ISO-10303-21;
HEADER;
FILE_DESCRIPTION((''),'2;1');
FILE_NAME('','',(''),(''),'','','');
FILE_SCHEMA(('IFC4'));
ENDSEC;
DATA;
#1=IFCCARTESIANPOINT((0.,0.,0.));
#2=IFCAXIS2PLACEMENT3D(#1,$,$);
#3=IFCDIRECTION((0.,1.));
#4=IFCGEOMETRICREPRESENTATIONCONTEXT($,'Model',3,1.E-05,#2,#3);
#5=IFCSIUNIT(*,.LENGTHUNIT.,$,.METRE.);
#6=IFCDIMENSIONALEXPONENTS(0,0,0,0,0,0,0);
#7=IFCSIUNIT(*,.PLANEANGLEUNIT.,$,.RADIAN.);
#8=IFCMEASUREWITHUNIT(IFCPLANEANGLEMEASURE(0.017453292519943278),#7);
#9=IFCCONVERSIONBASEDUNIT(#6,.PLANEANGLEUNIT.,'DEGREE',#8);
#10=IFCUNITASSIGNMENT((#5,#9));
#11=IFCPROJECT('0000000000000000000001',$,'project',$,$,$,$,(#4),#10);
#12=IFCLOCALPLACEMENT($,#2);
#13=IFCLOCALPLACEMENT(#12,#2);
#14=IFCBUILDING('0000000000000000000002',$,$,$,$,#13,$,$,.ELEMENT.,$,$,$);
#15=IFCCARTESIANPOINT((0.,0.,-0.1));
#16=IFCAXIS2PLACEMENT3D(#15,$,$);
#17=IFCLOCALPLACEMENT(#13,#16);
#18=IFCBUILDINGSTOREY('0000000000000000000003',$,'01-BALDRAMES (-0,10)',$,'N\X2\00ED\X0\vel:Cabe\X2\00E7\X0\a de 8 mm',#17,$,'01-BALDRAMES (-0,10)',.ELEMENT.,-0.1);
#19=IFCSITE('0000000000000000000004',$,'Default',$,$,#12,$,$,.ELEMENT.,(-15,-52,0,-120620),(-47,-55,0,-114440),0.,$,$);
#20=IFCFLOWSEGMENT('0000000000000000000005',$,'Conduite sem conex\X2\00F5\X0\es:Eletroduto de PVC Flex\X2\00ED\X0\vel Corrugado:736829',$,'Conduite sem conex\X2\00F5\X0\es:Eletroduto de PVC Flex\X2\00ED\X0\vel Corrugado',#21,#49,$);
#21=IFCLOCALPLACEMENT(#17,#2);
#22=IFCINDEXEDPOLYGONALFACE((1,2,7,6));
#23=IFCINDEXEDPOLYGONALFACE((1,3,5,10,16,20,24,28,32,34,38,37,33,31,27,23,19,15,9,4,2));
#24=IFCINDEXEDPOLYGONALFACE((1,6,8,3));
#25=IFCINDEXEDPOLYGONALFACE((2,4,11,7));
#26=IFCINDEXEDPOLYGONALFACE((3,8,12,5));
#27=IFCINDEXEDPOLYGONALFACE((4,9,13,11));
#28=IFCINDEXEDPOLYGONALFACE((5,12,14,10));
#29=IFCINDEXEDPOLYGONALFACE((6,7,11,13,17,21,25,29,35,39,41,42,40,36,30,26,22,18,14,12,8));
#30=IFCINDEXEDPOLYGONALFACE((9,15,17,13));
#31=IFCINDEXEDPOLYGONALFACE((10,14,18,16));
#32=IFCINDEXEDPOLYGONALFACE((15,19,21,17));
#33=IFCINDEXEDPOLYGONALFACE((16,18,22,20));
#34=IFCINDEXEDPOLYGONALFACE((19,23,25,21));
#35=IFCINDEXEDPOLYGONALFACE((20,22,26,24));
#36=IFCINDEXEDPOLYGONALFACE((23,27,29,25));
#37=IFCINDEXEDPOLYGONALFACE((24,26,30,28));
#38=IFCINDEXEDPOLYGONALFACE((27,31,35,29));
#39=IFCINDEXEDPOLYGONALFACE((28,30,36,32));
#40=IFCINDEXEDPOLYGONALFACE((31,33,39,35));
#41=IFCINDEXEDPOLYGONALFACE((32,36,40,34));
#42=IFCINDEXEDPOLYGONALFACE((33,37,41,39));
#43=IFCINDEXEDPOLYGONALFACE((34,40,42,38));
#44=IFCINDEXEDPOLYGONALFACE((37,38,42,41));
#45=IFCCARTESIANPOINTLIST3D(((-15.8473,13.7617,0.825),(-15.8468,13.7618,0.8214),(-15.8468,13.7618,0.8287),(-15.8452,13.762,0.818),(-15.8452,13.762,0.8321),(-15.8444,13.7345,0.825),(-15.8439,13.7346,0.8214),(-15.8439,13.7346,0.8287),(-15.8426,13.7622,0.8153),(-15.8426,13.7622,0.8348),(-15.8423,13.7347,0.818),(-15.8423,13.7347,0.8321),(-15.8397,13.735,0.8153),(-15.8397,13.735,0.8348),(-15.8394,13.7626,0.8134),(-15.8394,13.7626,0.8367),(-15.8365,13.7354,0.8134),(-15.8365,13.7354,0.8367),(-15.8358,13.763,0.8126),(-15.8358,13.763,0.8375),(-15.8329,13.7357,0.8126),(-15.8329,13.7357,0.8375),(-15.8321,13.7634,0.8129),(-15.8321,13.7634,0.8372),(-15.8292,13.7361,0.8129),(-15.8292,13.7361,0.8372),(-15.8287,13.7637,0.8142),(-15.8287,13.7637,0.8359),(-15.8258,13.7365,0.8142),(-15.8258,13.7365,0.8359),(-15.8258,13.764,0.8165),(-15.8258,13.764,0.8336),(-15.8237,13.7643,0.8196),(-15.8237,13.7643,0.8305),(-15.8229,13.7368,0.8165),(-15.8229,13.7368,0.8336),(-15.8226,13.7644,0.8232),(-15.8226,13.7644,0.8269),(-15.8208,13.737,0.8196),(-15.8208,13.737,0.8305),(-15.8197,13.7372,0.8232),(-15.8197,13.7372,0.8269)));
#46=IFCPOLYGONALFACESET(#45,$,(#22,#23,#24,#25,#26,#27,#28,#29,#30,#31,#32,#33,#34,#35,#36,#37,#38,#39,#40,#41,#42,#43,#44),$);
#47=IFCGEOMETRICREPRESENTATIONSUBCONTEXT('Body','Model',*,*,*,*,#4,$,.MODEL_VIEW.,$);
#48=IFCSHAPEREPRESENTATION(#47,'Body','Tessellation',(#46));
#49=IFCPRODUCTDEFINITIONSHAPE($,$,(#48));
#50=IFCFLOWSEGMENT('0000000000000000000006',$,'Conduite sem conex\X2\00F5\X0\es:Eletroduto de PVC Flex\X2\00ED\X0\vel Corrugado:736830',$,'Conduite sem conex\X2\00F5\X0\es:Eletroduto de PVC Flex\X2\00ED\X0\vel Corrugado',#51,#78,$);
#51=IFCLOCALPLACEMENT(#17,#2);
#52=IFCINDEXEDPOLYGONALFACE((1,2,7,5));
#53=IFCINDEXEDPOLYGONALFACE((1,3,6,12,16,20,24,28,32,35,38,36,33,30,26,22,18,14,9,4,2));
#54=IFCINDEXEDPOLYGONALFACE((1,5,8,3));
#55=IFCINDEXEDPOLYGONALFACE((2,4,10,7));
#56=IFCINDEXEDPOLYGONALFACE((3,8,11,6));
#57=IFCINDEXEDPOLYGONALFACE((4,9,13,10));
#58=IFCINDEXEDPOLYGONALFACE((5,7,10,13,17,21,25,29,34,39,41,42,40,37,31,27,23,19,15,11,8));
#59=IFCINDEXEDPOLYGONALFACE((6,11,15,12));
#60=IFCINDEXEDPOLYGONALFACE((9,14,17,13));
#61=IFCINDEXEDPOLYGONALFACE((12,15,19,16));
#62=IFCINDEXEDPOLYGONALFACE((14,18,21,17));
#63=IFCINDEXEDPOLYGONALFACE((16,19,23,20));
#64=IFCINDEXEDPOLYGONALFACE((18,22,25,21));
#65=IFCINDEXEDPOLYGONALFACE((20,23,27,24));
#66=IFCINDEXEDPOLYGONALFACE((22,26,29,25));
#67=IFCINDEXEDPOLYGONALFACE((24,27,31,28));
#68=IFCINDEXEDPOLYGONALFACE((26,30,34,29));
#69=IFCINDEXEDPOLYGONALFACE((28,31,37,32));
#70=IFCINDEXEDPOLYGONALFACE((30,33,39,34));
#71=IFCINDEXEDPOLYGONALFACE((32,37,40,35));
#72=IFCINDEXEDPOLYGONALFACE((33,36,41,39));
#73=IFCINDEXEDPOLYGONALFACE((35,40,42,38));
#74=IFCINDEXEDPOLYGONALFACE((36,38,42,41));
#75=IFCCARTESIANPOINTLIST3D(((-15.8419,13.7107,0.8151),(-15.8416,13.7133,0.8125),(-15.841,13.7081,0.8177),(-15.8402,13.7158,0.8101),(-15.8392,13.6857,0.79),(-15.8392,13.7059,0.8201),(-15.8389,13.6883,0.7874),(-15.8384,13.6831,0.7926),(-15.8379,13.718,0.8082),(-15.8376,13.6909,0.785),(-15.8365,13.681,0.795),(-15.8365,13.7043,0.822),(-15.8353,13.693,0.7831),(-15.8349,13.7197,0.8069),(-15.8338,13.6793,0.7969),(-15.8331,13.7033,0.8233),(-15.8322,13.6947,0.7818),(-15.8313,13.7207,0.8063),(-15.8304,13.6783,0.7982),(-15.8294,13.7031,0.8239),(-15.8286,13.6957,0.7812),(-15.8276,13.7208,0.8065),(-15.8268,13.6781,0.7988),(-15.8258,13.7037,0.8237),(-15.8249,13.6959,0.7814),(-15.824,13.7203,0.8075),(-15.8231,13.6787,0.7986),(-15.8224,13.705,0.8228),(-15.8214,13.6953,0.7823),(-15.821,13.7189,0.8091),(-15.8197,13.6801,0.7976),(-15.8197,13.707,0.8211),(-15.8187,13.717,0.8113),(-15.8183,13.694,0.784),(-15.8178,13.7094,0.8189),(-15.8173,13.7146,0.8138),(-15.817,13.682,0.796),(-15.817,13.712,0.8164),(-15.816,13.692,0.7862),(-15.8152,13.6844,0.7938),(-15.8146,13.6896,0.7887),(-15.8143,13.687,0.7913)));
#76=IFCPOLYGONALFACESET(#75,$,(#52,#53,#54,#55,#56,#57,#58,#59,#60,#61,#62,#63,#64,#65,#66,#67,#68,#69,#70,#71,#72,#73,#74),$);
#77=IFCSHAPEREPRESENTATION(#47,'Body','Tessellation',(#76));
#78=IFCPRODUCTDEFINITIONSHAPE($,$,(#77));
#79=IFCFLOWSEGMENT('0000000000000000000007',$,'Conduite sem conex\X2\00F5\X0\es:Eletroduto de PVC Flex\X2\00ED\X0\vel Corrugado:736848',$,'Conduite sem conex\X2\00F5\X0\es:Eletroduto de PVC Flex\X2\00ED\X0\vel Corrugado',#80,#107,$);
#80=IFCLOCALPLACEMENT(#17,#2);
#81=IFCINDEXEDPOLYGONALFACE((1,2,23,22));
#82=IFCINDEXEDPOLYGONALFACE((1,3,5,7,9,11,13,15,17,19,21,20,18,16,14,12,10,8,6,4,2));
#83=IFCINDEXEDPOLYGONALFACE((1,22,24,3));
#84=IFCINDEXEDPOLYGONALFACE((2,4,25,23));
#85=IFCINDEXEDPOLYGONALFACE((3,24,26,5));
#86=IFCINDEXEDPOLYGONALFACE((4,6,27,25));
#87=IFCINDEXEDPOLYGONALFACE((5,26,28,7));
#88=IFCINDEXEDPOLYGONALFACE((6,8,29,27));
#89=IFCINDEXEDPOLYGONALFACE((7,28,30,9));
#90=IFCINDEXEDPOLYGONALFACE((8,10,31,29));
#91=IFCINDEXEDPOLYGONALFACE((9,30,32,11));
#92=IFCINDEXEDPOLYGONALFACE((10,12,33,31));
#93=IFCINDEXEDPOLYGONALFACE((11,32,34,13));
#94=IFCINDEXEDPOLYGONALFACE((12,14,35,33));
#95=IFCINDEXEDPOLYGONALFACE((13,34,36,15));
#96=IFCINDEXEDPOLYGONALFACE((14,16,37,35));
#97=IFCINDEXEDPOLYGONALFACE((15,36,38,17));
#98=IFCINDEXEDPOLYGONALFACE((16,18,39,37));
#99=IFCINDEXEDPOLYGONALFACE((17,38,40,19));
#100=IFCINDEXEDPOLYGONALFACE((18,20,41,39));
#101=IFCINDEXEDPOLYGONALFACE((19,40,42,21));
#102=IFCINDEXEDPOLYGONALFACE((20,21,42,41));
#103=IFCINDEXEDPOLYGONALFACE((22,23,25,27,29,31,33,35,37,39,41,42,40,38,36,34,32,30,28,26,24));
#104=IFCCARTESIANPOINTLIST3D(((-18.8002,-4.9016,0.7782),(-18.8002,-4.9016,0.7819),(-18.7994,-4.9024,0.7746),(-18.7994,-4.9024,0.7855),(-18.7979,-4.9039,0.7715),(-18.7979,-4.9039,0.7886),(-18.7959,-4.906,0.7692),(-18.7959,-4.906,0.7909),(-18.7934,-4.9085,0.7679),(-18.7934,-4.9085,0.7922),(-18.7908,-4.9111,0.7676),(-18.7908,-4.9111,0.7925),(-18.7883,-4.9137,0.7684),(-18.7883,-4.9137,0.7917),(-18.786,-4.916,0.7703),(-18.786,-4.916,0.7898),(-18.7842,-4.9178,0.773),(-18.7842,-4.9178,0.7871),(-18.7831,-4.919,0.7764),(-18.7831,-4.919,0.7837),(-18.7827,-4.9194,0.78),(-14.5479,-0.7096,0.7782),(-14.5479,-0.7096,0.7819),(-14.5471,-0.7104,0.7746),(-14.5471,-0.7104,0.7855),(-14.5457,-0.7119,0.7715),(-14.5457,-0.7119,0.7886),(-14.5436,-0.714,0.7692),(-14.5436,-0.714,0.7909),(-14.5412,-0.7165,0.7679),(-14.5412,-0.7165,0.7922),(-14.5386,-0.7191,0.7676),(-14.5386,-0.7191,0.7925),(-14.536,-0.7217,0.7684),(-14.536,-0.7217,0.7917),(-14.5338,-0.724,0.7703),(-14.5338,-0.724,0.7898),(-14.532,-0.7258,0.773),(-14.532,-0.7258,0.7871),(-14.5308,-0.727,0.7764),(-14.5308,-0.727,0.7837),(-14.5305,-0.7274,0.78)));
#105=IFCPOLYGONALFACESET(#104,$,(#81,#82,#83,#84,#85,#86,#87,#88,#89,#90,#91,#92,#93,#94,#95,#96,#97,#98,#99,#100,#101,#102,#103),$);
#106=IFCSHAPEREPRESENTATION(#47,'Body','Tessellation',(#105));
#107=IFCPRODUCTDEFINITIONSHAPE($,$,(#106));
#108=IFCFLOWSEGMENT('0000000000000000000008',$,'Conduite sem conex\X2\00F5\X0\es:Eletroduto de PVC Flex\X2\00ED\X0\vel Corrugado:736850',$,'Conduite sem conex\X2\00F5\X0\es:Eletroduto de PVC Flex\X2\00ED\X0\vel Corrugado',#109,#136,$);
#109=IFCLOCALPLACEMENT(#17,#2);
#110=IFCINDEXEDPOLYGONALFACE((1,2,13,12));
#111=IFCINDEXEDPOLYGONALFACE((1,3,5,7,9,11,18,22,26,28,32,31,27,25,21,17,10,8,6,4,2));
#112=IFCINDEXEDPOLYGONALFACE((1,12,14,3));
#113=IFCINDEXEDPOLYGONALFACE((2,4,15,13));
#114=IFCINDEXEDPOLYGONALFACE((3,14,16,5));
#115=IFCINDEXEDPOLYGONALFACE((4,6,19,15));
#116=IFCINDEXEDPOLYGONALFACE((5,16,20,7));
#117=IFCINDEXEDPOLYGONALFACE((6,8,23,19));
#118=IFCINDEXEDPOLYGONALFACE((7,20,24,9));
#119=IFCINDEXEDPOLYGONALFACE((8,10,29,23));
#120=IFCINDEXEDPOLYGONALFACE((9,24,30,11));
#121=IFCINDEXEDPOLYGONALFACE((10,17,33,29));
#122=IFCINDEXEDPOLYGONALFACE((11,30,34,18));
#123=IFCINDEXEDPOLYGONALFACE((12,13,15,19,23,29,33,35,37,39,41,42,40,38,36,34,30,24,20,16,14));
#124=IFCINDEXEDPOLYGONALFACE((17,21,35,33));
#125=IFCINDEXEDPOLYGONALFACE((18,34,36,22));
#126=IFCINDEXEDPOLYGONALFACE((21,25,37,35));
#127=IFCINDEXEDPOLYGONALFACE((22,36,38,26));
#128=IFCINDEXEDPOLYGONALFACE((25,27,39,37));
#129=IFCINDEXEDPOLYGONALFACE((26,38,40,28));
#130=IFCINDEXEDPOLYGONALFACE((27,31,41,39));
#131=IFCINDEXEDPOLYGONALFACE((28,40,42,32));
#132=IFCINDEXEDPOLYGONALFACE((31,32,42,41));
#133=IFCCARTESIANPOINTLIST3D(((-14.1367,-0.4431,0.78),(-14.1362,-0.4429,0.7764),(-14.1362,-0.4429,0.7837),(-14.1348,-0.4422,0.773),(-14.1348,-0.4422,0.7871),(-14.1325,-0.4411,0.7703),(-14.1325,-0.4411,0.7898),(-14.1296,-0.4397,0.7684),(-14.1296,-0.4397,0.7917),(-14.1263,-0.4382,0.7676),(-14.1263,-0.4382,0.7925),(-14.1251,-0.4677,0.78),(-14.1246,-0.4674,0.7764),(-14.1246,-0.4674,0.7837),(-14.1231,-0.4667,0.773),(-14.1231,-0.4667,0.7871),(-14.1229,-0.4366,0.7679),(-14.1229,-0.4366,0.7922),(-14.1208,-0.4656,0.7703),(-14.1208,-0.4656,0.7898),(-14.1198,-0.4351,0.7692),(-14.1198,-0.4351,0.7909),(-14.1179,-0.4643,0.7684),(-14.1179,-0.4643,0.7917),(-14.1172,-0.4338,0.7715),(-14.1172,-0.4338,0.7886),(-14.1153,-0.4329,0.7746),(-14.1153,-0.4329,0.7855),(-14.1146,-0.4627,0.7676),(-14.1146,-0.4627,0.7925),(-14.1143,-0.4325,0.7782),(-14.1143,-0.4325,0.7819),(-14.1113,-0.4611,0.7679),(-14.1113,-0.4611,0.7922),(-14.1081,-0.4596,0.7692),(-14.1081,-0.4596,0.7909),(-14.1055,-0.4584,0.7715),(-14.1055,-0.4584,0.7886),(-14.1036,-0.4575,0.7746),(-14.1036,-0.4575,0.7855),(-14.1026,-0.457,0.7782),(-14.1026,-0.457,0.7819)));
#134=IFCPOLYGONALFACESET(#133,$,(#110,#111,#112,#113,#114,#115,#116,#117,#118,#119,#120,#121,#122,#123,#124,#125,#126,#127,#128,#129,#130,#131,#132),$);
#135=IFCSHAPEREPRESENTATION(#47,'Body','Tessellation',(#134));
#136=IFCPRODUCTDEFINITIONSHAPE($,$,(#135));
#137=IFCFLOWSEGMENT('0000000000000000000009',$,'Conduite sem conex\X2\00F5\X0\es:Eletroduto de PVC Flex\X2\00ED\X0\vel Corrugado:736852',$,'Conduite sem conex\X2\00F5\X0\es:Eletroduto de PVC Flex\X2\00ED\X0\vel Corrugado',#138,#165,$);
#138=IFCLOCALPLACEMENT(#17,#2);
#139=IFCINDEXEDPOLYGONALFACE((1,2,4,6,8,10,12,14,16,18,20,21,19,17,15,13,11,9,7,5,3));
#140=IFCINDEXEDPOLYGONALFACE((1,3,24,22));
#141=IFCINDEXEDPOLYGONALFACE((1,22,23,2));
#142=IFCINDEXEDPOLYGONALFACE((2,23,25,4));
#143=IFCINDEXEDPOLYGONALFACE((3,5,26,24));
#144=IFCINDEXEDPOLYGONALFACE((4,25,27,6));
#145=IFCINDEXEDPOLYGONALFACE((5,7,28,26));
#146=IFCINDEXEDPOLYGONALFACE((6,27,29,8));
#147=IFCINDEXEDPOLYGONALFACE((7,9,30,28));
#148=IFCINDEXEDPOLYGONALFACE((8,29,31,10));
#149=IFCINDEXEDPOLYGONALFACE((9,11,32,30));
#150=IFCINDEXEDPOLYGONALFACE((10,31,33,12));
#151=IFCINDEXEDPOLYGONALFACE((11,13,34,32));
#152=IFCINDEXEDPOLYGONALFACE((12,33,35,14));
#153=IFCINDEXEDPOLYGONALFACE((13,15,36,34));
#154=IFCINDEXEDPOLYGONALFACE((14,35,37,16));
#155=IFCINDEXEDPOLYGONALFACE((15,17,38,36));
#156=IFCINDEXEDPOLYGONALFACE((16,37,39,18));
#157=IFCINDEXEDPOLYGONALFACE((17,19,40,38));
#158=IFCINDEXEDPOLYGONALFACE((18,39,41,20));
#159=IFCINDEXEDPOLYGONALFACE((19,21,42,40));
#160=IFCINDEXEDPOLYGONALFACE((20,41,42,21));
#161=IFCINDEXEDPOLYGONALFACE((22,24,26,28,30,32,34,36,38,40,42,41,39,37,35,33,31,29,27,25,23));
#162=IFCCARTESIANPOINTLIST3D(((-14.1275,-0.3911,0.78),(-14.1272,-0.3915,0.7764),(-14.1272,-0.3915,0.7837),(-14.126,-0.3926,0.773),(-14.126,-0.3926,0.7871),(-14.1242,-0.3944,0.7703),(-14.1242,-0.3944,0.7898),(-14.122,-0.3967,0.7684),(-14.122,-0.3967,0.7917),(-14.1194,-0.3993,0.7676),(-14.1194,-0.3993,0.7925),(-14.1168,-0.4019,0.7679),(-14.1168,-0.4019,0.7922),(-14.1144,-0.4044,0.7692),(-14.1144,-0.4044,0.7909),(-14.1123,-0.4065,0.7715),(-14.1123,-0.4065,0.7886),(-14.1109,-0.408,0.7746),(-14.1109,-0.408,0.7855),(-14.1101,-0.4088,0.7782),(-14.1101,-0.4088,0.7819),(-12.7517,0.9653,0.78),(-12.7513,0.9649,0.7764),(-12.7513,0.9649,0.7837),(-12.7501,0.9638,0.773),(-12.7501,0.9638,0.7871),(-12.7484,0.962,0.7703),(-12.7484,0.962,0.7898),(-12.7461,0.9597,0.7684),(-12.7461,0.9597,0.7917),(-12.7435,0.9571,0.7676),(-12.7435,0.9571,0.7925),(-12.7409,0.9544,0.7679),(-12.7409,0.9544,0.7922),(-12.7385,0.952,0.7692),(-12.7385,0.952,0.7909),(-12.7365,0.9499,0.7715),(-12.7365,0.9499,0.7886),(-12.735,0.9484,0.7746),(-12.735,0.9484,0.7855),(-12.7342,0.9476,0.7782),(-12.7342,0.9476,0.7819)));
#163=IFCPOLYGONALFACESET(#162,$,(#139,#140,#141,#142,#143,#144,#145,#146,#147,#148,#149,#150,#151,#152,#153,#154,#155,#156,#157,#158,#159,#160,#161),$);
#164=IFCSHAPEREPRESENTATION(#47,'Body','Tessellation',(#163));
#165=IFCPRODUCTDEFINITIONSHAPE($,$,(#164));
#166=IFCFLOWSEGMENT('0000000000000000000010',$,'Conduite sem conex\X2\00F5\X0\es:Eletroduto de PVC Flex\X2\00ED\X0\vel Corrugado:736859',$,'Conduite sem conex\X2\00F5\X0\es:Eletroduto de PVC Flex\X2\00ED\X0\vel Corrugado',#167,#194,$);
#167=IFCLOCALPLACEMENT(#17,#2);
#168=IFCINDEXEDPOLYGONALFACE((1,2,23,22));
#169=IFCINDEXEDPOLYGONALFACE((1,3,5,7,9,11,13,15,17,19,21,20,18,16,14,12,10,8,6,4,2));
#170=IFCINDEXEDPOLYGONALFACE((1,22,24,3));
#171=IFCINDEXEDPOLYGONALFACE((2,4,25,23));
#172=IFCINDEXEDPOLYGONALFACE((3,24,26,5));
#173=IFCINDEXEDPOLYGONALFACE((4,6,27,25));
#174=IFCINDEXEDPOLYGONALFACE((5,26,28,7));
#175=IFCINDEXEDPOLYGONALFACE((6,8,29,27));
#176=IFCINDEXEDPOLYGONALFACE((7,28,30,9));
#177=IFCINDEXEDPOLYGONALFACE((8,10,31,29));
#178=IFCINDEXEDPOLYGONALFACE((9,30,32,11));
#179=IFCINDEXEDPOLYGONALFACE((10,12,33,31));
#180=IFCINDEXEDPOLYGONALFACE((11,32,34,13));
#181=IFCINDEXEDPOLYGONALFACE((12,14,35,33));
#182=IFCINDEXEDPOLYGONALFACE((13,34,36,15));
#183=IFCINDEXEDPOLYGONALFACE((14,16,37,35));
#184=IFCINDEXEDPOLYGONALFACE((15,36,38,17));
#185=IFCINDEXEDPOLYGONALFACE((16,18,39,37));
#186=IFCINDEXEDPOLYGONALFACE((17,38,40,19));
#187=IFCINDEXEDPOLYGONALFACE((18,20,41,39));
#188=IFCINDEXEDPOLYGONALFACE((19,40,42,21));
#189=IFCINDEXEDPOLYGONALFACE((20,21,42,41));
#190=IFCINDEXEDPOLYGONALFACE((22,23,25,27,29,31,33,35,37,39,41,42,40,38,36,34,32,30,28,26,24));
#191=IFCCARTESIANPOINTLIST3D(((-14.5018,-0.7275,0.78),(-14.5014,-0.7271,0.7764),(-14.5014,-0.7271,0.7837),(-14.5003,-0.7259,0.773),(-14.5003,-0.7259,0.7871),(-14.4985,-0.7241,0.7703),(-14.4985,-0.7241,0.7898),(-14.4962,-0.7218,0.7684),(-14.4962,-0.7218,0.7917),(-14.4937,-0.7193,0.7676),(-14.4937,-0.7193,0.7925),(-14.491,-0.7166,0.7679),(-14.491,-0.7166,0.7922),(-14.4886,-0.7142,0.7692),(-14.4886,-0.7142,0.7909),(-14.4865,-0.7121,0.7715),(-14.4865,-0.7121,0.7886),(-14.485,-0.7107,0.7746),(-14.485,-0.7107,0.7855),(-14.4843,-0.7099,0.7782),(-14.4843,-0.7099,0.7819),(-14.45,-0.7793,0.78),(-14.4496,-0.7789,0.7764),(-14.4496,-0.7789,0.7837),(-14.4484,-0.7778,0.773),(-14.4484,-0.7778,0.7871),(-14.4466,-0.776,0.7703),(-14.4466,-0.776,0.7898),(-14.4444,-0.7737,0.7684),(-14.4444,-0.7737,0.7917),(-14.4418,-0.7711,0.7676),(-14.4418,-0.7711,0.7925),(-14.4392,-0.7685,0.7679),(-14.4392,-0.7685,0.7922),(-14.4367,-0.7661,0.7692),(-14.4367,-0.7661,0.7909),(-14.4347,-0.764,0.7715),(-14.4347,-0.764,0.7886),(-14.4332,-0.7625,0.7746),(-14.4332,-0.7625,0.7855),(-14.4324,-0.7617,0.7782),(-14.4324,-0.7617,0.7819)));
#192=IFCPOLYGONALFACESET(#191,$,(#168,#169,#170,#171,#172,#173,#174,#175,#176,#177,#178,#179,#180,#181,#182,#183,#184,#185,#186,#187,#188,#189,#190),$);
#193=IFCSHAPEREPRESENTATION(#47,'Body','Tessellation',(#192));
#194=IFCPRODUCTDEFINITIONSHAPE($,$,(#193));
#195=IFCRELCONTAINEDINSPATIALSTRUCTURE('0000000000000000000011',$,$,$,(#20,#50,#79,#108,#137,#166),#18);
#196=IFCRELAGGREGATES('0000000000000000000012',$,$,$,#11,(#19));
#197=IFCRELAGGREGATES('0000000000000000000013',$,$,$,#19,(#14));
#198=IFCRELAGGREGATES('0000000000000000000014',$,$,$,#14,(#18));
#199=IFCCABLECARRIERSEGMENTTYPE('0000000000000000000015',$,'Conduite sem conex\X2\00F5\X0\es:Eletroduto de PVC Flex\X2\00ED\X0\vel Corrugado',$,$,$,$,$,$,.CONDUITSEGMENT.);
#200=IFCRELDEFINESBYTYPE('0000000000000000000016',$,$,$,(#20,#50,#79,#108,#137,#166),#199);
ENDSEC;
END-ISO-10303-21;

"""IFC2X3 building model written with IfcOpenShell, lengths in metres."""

from ifc_helpers import new_model, entity, si_unit, converted_unit, direction, frame, frame_2d, origin, origin_2d_with_axis, place, context, subcontext, project, spatial, circle, extrude, type_object, element, save


model = new_model("IFC2X3")

# Units and contexts
model_context = context("Model", 3, precision=1e-05, world=origin(), true_north=direction((0.0, 1.0)))
body_context = subcontext(model_context, "Body", "Model", "MODEL_VIEW")
ifc_project = project(units=[si_unit("LENGTHUNIT", "METRE"), converted_unit("PLANEANGLEUNIT", "DEGREE", entity("IfcPlaneAngleMeasure", 0.017453292519943278), si_unit("PLANEANGLEUNIT", "RADIAN"), dimensions=[0, 0, 0, 0, 0, 0, 0])], contexts=[model_context])

# Site, building, storey
site_placement = place(None, origin())
site = spatial("IfcSite", under=ifc_project, at=site_placement, Name="Default", CompositionType="ELEMENT", RefLatitude=(-15, -52, 0, -120620), RefLongitude=(-47, -55, 0, -114440), RefElevation=0.0)
building_placement = place(site_placement, origin())
building = spatial("IfcBuilding", under=site, at=building_placement, CompositionType="ELEMENT")
storey_placement = place(building_placement, frame((0.0, 0.0, -0.1)))
storey = spatial("IfcBuildingStorey", under=building, at=storey_placement, Name="01-BALDRAMES (-0,10)", ObjectType="Nível:Cabeça de 8 mm", LongName="01-BALDRAMES (-0,10)", CompositionType="ELEMENT", Elevation=-0.1)

# Flow segments
cable_carrier_segment_type = type_object("IfcCableCarrierSegmentType", Name="Conduite sem conexões:Eletroduto de PVC Flexível Corrugado", PredefinedType="CONDUITSEGMENT")
flow_segment_1_placement = place(storey_placement, origin())
element("IfcFlowSegment", 1, at=flow_segment_1_placement, inside=storey, type_object=cable_carrier_segment_type, Name="Conduite sem conexões:Eletroduto de PVC Flexível Corrugado:736829", ObjectType="Conduite sem conexões:Eletroduto de PVC Flexível Corrugado", context=body_context, shape_type="SweptSolid", body=[
    extrude(circle(Radius=0.0125, at=origin_2d_with_axis()), frame((-15.8349, 13.7631, 0.825), z_axis=(0.106176, -0.994347, 0.0), x_axis=(-0.994347, -0.106176, 0.0)), (0.0, 0.0, 1.0), 0.0274),
])
flow_segment_2_placement = place(storey_placement, origin())
element("IfcFlowSegment", 2, at=flow_segment_2_placement, inside=storey, type_object=cable_carrier_segment_type, Name="Conduite sem conexões:Eletroduto de PVC Flexível Corrugado:736830", ObjectType="Conduite sem conexões:Eletroduto de PVC Flexível Corrugado", context=body_context, shape_type="SweptSolid", body=[
    extrude(circle(Radius=0.0125, at=origin_2d_with_axis()), frame((-15.8294, 13.712, 0.8151), z_axis=(0.075078, -0.70311, -0.707107), x_axis=(-0.994347, -0.106176, 0.0)), (0.0, 0.0, 1.0), 0.0355),
])
flow_segment_3_placement = place(storey_placement, origin())
element("IfcFlowSegment", 3, at=flow_segment_3_placement, inside=storey, type_object=cable_carrier_segment_type, Name="Conduite sem conexões:Eletroduto de PVC Flexível Corrugado:736848", ObjectType="Conduite sem conexões:Eletroduto de PVC Flexível Corrugado", context=body_context, shape_type="SweptSolid", body=[
    extrude(circle(Radius=0.0125, at=origin_2d_with_axis()), frame((-18.7915, -4.9105, 0.78), z_axis=(0.712135, 0.702042, 0.0), x_axis=(0.702042, -0.712135, 0.0)), (0.0, 0.0, 1.0), 5.9711),
])
flow_segment_4_placement = place(storey_placement, origin())
element("IfcFlowSegment", 4, at=flow_segment_4_placement, inside=storey, type_object=cable_carrier_segment_type, Name="Conduite sem conexões:Eletroduto de PVC Flexível Corrugado:736850", ObjectType="Conduite sem conexões:Eletroduto de PVC Flexível Corrugado", context=body_context, shape_type="SweptSolid", body=[
    extrude(circle(Radius=0.0125, at=frame_2d((0.0, 0.0), x_axis=(1.0, 0.0))), frame((-14.1138, -0.4623, 0.78), z_axis=(-0.428806, 0.903397, 0.0), x_axis=(-0.903397, -0.428806, 0.0)), (0.0, 0.0, 1.0), 0.0272),
])
flow_segment_5_placement = place(storey_placement, origin())
element("IfcFlowSegment", 5, at=flow_segment_5_placement, inside=storey, type_object=cable_carrier_segment_type, Name="Conduite sem conexões:Eletroduto de PVC Flexível Corrugado:736852", ObjectType="Conduite sem conexões:Eletroduto de PVC Flexível Corrugado", context=body_context, shape_type="SweptSolid", body=[
    extrude(circle(Radius=0.0125, at=frame_2d((0.0, 0.0), x_axis=(1.0, 0.0))), frame((-14.1188, -0.4, 0.78), z_axis=(0.712135, 0.702042, 0.0), x_axis=(-0.702042, 0.712135, 0.0)), (0.0, 0.0, 1.0), 1.932),
])
flow_segment_6_placement = place(storey_placement, origin())
element("IfcFlowSegment", 6, at=flow_segment_6_placement, inside=storey, type_object=cable_carrier_segment_type, Name="Conduite sem conexões:Eletroduto de PVC Flexível Corrugado:736859", ObjectType="Conduite sem conexões:Eletroduto de PVC Flexível Corrugado", context=body_context, shape_type="SweptSolid", body=[
    extrude(circle(Radius=0.0125, at=frame_2d((0.0, 0.0), x_axis=(1.0, 0.0))), frame((-14.493, -0.7186, 0.78), z_axis=(0.707107, -0.707107, 0.0), x_axis=(-0.707107, -0.707107, 0.0)), (0.0, 0.0, 1.0), 0.0733),
])

save(model, "model.ifc")
